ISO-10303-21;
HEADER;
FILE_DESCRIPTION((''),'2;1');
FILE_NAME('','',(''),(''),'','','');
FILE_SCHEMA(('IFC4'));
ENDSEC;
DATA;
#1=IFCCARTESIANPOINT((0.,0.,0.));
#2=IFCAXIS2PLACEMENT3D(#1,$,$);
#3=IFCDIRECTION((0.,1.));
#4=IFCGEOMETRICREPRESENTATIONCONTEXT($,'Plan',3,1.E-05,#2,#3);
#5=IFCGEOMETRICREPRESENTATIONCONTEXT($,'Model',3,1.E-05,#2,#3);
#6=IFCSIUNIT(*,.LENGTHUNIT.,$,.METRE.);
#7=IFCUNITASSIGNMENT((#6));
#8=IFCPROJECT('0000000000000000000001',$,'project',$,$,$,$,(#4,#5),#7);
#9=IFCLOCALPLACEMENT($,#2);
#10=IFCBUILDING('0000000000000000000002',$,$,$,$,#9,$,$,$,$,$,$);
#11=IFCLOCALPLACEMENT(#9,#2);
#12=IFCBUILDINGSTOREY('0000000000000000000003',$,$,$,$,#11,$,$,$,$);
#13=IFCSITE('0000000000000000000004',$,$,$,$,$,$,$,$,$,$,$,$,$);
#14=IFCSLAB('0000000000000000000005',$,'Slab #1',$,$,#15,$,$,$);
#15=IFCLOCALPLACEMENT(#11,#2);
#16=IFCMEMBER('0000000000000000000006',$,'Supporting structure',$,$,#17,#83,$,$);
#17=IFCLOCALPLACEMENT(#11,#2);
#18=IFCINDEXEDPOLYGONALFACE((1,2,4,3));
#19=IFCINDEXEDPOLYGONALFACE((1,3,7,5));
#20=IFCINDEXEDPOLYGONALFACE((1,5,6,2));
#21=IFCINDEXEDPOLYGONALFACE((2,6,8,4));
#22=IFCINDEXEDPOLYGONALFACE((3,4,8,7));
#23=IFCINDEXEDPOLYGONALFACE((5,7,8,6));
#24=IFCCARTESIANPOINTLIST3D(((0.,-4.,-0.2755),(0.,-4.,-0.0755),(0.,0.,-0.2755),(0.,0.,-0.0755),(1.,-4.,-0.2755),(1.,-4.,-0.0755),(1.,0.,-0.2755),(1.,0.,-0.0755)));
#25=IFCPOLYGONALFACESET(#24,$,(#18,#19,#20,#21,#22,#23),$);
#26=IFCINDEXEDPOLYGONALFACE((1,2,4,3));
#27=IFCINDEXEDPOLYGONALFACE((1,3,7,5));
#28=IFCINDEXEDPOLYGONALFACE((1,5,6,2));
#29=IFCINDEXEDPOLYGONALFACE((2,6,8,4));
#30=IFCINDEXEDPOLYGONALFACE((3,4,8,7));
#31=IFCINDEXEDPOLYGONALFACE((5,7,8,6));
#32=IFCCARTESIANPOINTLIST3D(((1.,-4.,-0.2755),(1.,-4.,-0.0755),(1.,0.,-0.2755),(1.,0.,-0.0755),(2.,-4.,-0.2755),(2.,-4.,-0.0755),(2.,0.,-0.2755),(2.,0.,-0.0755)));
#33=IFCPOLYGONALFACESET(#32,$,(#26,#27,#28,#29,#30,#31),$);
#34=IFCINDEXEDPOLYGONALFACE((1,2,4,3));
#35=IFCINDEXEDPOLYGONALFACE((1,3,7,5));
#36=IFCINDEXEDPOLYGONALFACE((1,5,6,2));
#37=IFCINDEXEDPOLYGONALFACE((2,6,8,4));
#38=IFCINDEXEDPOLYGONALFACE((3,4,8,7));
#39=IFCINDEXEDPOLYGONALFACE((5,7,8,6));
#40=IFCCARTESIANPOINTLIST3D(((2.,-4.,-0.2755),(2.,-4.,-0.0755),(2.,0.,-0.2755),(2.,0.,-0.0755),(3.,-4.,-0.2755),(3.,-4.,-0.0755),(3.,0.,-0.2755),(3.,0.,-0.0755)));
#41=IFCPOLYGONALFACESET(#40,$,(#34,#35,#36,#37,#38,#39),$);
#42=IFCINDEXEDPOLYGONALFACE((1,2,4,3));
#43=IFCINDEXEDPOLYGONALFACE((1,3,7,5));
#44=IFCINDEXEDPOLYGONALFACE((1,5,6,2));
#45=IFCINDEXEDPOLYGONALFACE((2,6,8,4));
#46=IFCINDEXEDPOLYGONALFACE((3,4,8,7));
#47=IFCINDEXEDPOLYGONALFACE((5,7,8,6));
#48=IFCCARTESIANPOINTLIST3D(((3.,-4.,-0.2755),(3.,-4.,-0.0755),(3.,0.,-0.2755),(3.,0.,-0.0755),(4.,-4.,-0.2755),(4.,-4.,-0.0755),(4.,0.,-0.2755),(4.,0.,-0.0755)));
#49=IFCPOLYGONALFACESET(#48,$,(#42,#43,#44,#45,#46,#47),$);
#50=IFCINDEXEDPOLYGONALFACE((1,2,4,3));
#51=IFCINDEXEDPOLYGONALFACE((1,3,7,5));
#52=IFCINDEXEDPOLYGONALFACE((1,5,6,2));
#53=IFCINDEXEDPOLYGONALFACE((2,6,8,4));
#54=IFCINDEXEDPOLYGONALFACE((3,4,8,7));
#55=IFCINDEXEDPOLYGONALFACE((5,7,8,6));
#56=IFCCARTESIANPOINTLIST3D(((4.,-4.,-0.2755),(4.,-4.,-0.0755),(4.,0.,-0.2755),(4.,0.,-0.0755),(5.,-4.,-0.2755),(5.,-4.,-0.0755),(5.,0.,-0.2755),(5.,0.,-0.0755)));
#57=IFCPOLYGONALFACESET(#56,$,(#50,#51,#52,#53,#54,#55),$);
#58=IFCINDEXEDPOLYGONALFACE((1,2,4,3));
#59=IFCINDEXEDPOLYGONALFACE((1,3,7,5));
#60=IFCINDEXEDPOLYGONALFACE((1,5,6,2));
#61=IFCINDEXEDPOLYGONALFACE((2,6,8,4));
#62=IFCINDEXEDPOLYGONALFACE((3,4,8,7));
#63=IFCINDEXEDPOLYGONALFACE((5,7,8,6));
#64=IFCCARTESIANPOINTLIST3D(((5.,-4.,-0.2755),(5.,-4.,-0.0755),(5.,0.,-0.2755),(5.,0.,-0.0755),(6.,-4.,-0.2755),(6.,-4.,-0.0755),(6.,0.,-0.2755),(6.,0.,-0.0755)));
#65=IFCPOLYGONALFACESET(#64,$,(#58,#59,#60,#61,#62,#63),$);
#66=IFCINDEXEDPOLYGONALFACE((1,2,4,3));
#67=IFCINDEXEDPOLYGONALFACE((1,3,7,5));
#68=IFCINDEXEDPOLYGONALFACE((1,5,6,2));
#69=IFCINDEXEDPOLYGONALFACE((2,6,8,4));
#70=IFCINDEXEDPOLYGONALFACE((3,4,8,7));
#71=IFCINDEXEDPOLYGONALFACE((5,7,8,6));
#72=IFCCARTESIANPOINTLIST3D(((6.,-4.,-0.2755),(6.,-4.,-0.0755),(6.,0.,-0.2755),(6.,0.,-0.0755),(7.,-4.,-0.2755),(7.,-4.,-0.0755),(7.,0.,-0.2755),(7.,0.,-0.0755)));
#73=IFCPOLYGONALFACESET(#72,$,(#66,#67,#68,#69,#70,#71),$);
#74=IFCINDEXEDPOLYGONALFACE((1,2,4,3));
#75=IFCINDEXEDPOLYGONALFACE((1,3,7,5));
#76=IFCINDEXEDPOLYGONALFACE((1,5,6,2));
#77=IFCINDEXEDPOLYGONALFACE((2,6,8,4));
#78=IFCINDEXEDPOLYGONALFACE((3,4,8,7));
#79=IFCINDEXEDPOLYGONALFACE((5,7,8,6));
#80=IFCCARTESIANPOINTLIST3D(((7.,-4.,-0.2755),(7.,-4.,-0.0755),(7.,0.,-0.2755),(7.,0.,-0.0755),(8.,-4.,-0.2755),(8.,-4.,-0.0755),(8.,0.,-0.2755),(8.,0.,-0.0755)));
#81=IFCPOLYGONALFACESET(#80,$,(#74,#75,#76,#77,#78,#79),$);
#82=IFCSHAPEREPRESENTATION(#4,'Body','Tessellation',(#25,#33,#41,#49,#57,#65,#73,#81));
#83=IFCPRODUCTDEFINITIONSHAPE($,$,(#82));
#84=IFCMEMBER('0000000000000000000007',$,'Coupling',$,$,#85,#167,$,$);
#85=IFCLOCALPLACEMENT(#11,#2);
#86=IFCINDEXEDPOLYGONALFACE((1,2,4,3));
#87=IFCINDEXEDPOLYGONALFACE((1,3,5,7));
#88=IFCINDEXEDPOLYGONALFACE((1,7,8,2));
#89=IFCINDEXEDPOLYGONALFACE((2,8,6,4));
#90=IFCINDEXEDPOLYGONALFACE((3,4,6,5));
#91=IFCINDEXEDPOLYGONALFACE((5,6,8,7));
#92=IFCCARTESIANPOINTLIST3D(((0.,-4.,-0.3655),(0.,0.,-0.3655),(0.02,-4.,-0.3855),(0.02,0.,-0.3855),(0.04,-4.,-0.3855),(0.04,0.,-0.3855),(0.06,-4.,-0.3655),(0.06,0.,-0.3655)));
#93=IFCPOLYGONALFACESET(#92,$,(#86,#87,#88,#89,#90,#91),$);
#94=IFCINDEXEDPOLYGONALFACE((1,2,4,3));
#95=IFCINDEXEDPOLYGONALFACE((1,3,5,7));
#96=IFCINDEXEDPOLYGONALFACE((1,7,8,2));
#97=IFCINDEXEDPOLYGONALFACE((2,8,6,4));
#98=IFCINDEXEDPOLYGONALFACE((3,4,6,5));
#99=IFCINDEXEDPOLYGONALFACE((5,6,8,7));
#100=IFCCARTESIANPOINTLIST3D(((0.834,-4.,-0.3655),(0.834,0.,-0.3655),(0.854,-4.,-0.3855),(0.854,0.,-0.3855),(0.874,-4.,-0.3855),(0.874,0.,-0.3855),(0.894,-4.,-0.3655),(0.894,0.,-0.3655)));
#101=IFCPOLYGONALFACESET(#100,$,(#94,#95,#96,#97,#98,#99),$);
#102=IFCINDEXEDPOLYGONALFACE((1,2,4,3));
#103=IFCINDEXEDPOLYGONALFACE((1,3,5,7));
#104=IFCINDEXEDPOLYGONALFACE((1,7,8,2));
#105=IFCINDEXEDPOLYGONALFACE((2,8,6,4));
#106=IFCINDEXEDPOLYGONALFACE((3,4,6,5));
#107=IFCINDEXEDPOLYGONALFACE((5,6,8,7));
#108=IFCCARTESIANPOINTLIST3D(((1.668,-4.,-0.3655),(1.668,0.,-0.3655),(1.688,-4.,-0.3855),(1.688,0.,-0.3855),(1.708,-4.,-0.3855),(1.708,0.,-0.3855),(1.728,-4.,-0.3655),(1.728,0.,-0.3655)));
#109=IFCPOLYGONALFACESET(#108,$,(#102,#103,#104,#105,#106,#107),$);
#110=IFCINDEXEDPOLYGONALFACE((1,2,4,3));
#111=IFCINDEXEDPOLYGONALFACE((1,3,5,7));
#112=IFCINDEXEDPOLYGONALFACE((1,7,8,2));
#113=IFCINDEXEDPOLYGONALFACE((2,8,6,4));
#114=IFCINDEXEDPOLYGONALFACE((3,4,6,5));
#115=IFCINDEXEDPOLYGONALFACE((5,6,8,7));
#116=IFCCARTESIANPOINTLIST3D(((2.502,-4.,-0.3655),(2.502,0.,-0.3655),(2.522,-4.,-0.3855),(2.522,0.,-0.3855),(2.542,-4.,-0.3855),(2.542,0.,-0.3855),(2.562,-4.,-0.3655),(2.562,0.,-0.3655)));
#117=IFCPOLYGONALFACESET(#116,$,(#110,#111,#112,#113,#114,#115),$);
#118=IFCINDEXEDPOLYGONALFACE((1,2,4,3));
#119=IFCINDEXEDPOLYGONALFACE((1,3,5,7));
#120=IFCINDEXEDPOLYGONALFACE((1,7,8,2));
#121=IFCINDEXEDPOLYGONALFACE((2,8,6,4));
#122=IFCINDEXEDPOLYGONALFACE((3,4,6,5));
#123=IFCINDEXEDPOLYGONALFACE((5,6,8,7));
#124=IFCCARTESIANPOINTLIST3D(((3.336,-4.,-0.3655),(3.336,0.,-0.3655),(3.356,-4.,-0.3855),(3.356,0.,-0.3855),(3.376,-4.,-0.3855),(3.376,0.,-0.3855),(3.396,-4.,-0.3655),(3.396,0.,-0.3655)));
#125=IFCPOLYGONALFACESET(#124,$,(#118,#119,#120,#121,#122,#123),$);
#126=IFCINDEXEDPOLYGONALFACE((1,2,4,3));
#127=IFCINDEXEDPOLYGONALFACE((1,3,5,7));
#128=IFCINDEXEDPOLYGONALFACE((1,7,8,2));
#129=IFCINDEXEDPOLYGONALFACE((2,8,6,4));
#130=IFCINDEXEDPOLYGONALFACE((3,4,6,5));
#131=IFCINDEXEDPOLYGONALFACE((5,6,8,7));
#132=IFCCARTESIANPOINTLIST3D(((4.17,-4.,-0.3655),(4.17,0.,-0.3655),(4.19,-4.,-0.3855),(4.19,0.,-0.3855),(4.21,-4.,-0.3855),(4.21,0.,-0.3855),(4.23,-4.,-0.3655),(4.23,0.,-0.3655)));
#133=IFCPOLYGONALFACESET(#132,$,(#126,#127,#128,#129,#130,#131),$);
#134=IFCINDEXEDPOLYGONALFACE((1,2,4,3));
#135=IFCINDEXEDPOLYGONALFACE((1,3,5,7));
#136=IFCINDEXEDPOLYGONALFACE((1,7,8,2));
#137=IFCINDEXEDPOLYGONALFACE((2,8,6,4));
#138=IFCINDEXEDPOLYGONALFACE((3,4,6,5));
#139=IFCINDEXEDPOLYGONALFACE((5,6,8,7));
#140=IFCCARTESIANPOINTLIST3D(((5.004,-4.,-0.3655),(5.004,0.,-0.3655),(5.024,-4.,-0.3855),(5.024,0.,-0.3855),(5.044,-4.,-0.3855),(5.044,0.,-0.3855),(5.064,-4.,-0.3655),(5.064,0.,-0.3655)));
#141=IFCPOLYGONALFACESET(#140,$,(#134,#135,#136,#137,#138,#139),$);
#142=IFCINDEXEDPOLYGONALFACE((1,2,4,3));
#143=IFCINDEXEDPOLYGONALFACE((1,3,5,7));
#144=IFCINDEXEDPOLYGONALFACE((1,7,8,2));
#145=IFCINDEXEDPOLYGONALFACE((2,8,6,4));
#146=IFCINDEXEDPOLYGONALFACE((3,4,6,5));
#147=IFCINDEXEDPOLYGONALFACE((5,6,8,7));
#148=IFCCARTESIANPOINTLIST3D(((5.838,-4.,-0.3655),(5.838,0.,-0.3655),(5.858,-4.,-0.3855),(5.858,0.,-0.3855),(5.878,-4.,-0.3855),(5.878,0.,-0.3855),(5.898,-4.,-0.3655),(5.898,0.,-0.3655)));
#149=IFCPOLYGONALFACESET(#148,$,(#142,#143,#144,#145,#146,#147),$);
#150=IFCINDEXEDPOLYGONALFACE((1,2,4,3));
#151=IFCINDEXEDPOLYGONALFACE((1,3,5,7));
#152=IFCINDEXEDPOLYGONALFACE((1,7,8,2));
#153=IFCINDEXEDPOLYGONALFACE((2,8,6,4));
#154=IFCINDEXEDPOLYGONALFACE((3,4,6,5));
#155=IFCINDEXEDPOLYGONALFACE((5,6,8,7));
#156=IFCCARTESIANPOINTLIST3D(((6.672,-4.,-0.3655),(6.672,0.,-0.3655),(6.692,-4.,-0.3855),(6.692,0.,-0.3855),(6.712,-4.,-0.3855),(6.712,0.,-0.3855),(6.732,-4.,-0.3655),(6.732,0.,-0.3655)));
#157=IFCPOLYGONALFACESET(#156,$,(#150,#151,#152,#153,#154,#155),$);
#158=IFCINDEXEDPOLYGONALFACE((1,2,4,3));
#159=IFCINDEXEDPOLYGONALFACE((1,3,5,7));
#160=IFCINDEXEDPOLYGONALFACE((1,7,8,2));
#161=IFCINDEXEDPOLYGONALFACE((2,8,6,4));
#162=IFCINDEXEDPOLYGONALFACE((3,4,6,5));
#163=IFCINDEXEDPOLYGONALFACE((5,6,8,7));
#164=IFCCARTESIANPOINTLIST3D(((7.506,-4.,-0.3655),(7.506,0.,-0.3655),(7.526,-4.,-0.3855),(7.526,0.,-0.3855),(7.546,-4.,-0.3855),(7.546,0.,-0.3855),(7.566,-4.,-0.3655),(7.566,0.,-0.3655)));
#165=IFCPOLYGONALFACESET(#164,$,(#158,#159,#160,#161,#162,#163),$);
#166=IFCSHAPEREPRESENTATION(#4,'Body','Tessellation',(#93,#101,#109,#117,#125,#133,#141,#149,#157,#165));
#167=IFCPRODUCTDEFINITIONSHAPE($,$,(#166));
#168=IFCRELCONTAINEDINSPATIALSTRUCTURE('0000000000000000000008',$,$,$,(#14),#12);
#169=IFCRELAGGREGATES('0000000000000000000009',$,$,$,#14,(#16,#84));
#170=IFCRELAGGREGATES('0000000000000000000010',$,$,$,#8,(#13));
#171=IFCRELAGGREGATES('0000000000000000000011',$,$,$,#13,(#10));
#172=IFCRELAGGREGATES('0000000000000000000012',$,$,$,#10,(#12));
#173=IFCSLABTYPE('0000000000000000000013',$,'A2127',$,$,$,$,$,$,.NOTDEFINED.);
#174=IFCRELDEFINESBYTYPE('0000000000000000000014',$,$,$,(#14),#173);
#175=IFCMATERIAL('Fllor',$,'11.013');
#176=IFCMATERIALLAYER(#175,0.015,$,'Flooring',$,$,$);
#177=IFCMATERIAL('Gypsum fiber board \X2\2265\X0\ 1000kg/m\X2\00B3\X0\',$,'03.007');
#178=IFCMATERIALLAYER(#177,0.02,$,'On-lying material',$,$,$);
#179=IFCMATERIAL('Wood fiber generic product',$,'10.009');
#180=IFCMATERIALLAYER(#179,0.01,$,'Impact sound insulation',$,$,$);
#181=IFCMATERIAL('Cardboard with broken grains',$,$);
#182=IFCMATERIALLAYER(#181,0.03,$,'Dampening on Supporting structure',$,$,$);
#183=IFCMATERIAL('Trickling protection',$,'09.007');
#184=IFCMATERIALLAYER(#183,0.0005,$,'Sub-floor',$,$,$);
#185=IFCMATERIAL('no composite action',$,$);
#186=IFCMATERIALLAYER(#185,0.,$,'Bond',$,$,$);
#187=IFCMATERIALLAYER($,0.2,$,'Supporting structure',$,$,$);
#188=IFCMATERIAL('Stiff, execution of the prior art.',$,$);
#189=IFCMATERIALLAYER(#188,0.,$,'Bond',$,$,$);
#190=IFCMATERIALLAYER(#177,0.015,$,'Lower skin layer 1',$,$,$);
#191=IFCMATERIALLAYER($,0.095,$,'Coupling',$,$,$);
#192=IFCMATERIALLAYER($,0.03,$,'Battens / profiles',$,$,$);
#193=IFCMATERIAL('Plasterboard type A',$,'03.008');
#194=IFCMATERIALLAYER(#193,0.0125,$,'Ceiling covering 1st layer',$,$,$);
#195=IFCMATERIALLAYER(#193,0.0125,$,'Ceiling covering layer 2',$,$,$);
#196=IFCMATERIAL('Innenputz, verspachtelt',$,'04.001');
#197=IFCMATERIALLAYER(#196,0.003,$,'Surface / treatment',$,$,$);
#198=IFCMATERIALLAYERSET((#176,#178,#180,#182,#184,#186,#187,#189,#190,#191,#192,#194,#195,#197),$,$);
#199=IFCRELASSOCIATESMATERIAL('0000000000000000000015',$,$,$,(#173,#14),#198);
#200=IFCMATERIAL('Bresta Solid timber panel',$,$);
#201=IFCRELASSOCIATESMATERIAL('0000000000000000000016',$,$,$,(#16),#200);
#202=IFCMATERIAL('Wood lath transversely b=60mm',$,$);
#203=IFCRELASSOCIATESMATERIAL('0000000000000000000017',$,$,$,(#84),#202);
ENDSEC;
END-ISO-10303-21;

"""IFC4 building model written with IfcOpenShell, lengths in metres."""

from ifc_helpers import new_model, si_unit, direction, frame, frame_2d, origin, place, context, project, spatial, polyline, rectangle, outline, extrude, material, layer, layer_set, type_object, element, aggregate, save


model = new_model("IFC4")

# Units and contexts
plan_context = context("Plan", 3, precision=1e-05, world=origin(), true_north=direction((0.0, 1.0)))
model_context = context("Model", 3, precision=1e-05, world=origin(), true_north=direction((0.0, 1.0)))
ifc_project = project(units=[si_unit("LENGTHUNIT", "METRE")], contexts=[plan_context, model_context])

# Site, building, storey
site = spatial("IfcSite", under=ifc_project)
building_placement = place(None, origin())
building = spatial("IfcBuilding", under=site, at=building_placement)
storey_placement = place(building_placement, origin())
storey = spatial("IfcBuildingStorey", under=building, at=storey_placement)

# Slab, members
ifc_material_1 = material(Name="Fllor", Category="11.013")
ifc_layer_1 = layer(ifc_material_1, 0.015, Name="Flooring")
ifc_material_2 = material(Name="Gypsum fiber board ≥ 1000kg/m³", Category="03.007")
ifc_layer_2 = layer(ifc_material_2, 0.02, Name="On-lying material")
ifc_material_3 = material(Name="Wood fiber generic product", Category="10.009")
ifc_layer_3 = layer(ifc_material_3, 0.01, Name="Impact sound insulation")
ifc_material_4 = material(Name="Cardboard with broken grains")
ifc_layer_4 = layer(ifc_material_4, 0.03, Name="Dampening on Supporting structure")
ifc_material_5 = material(Name="Trickling protection", Category="09.007")
ifc_layer_5 = layer(ifc_material_5, 0.0005, Name="Sub-floor")
ifc_material_6 = material(Name="no composite action")
ifc_layer_6 = layer(ifc_material_6, 0.0, Name="Bond")
ifc_layer_7 = layer(None, 0.2, Name="Supporting structure")
ifc_material_7 = material(Name="Stiff, execution of the prior art.")
ifc_layer_8 = layer(ifc_material_7, 0.0, Name="Bond")
ifc_layer_9 = layer(ifc_material_2, 0.015, Name="Lower skin layer 1")
ifc_layer_10 = layer(None, 0.095, Name="Coupling")
ifc_layer_11 = layer(None, 0.03, Name="Battens / profiles")
ifc_material_8 = material(Name="Plasterboard type A", Category="03.008")
ifc_layer_12 = layer(ifc_material_8, 0.0125, Name="Ceiling covering 1st layer")
ifc_layer_13 = layer(ifc_material_8, 0.0125, Name="Ceiling covering layer 2")
ifc_material_9 = material(Name="Innenputz, verspachtelt", Category="04.001")
ifc_layer_14 = layer(ifc_material_9, 0.003, Name="Surface / treatment")
ifc_layer_set = layer_set([ifc_layer_1, ifc_layer_2, ifc_layer_3, ifc_layer_4, ifc_layer_5, ifc_layer_6, ifc_layer_7, ifc_layer_8, ifc_layer_9, ifc_layer_10, ifc_layer_11, ifc_layer_12, ifc_layer_13, ifc_layer_14])
slab_type = type_object("IfcSlabType", Name="A2127", PredefinedType="NOTDEFINED", material=ifc_layer_set)
slab_placement = place(None, frame((0.0, 0.0, 0.0), z_axis=(0.0, 0.0, -1.0), x_axis=(1.0, 0.0, 0.0)))
slab = element("IfcSlab", 1, at=slab_placement, inside=storey, type_object=slab_type, material=ifc_layer_set, Name="Slab #1")
ifc_material_10 = material(Name="Bresta Solid timber panel")
member_1_placement = place(slab_placement, origin())
member_1 = element("IfcMember", 2, at=member_1_placement, material=ifc_material_10, Name="Supporting structure", context=plan_context, shape_type="SweptSolid", body=[
    extrude(rectangle(XDim=1.0, YDim=0.2, at=frame_2d((0.5, 0.1), x_axis=(1.0, 0.0))), frame((0.0, 4.0, 0.0755), z_axis=(0.0, -1.0, 0.0), x_axis=(1.0, 0.0, 0.0)), (0.0, 0.0, 1.0), 4.0),
    extrude(rectangle(XDim=1.0, YDim=0.2, at=frame_2d((0.5, 0.1), x_axis=(1.0, 0.0))), frame((1.0, 4.0, 0.0755), z_axis=(0.0, -1.0, 0.0), x_axis=(1.0, 0.0, 0.0)), (0.0, 0.0, 1.0), 4.0),
    extrude(rectangle(XDim=1.0, YDim=0.2, at=frame_2d((0.5, 0.1), x_axis=(1.0, 0.0))), frame((2.0, 4.0, 0.0755), z_axis=(0.0, -1.0, 0.0), x_axis=(1.0, 0.0, 0.0)), (0.0, 0.0, 1.0), 4.0),
    extrude(rectangle(XDim=1.0, YDim=0.2, at=frame_2d((0.5, 0.1), x_axis=(1.0, 0.0))), frame((3.0, 4.0, 0.0755), z_axis=(0.0, -1.0, 0.0), x_axis=(1.0, 0.0, 0.0)), (0.0, 0.0, 1.0), 4.0),
    extrude(rectangle(XDim=1.0, YDim=0.2, at=frame_2d((0.5, 0.1), x_axis=(1.0, 0.0))), frame((4.0, 4.0, 0.0755), z_axis=(0.0, -1.0, 0.0), x_axis=(1.0, 0.0, 0.0)), (0.0, 0.0, 1.0), 4.0),
    extrude(rectangle(XDim=1.0, YDim=0.2, at=frame_2d((0.5, 0.1), x_axis=(1.0, 0.0))), frame((5.0, 4.0, 0.0755), z_axis=(0.0, -1.0, 0.0), x_axis=(1.0, 0.0, 0.0)), (0.0, 0.0, 1.0), 4.0),
    extrude(rectangle(XDim=1.0, YDim=0.2, at=frame_2d((0.5, 0.1), x_axis=(1.0, 0.0))), frame((6.0, 4.0, 0.0755), z_axis=(0.0, -1.0, 0.0), x_axis=(1.0, 0.0, 0.0)), (0.0, 0.0, 1.0), 4.0),
    extrude(rectangle(XDim=1.0, YDim=0.2, at=frame_2d((0.5, 0.1), x_axis=(1.0, 0.0))), frame((7.0, 4.0, 0.0755), z_axis=(0.0, -1.0, 0.0), x_axis=(1.0, 0.0, 0.0)), (0.0, 0.0, 1.0), 4.0),
])
ifc_material_11 = material(Name="Wood lath transversely b=60mm")
member_2_placement = place(slab_placement, origin())
member_2 = element("IfcMember", 3, at=member_2_placement, material=ifc_material_11, Name="Coupling", context=plan_context, shape_type="SweptSolid", body=[
    extrude(outline(polyline([(0.0, 0.0), (0.06, 0.0), (0.04, 0.02), (0.02, 0.02), (0.0, 0.0)])), frame((0.0, 4.0, 0.3655), z_axis=(0.0, -1.0, 0.0), x_axis=(1.0, 0.0, 0.0)), (0.0, 0.0, 1.0), 4.0),
    extrude(outline(polyline([(0.0, 0.0), (0.06, 0.0), (0.04, 0.02), (0.02, 0.02), (0.0, 0.0)])), frame((0.834, 4.0, 0.3655), z_axis=(0.0, -1.0, 0.0), x_axis=(1.0, 0.0, 0.0)), (0.0, 0.0, 1.0), 4.0),
    extrude(outline(polyline([(0.0, 0.0), (0.06, 0.0), (0.04, 0.02), (0.02, 0.02), (0.0, 0.0)])), frame((1.668, 4.0, 0.3655), z_axis=(0.0, -1.0, 0.0), x_axis=(1.0, 0.0, 0.0)), (0.0, 0.0, 1.0), 4.0),
    extrude(outline(polyline([(0.0, 0.0), (0.06, 0.0), (0.04, 0.02), (0.02, 0.02), (0.0, 0.0)])), frame((2.502, 4.0, 0.3655), z_axis=(0.0, -1.0, 0.0), x_axis=(1.0, 0.0, 0.0)), (0.0, 0.0, 1.0), 4.0),
    extrude(outline(polyline([(0.0, 0.0), (0.06, 0.0), (0.04, 0.02), (0.02, 0.02), (0.0, 0.0)])), frame((3.336, 4.0, 0.3655), z_axis=(0.0, -1.0, 0.0), x_axis=(1.0, 0.0, 0.0)), (0.0, 0.0, 1.0), 4.0),
    extrude(outline(polyline([(0.0, 0.0), (0.06, 0.0), (0.04, 0.02), (0.02, 0.02), (0.0, 0.0)])), frame((4.17, 4.0, 0.3655), z_axis=(0.0, -1.0, 0.0), x_axis=(1.0, 0.0, 0.0)), (0.0, 0.0, 1.0), 4.0),
    extrude(outline(polyline([(0.0, 0.0), (0.06, 0.0), (0.04, 0.02), (0.02, 0.02), (0.0, 0.0)])), frame((5.004, 4.0, 0.3655), z_axis=(0.0, -1.0, 0.0), x_axis=(1.0, 0.0, 0.0)), (0.0, 0.0, 1.0), 4.0),
    extrude(outline(polyline([(0.0, 0.0), (0.06, 0.0), (0.04, 0.02), (0.02, 0.02), (0.0, 0.0)])), frame((5.838, 4.0, 0.3655), z_axis=(0.0, -1.0, 0.0), x_axis=(1.0, 0.0, 0.0)), (0.0, 0.0, 1.0), 4.0),
    extrude(outline(polyline([(0.0, 0.0), (0.06, 0.0), (0.04, 0.02), (0.02, 0.02), (0.0, 0.0)])), frame((6.672, 4.0, 0.3655), z_axis=(0.0, -1.0, 0.0), x_axis=(1.0, 0.0, 0.0)), (0.0, 0.0, 1.0), 4.0),
    extrude(outline(polyline([(0.0, 0.0), (0.06, 0.0), (0.04, 0.02), (0.02, 0.02), (0.0, 0.0)])), frame((7.506, 4.0, 0.3655), z_axis=(0.0, -1.0, 0.0), x_axis=(1.0, 0.0, 0.0)), (0.0, 0.0, 1.0), 4.0),
])
aggregate(slab, [member_1, member_2])

save(model, "model.ifc")
